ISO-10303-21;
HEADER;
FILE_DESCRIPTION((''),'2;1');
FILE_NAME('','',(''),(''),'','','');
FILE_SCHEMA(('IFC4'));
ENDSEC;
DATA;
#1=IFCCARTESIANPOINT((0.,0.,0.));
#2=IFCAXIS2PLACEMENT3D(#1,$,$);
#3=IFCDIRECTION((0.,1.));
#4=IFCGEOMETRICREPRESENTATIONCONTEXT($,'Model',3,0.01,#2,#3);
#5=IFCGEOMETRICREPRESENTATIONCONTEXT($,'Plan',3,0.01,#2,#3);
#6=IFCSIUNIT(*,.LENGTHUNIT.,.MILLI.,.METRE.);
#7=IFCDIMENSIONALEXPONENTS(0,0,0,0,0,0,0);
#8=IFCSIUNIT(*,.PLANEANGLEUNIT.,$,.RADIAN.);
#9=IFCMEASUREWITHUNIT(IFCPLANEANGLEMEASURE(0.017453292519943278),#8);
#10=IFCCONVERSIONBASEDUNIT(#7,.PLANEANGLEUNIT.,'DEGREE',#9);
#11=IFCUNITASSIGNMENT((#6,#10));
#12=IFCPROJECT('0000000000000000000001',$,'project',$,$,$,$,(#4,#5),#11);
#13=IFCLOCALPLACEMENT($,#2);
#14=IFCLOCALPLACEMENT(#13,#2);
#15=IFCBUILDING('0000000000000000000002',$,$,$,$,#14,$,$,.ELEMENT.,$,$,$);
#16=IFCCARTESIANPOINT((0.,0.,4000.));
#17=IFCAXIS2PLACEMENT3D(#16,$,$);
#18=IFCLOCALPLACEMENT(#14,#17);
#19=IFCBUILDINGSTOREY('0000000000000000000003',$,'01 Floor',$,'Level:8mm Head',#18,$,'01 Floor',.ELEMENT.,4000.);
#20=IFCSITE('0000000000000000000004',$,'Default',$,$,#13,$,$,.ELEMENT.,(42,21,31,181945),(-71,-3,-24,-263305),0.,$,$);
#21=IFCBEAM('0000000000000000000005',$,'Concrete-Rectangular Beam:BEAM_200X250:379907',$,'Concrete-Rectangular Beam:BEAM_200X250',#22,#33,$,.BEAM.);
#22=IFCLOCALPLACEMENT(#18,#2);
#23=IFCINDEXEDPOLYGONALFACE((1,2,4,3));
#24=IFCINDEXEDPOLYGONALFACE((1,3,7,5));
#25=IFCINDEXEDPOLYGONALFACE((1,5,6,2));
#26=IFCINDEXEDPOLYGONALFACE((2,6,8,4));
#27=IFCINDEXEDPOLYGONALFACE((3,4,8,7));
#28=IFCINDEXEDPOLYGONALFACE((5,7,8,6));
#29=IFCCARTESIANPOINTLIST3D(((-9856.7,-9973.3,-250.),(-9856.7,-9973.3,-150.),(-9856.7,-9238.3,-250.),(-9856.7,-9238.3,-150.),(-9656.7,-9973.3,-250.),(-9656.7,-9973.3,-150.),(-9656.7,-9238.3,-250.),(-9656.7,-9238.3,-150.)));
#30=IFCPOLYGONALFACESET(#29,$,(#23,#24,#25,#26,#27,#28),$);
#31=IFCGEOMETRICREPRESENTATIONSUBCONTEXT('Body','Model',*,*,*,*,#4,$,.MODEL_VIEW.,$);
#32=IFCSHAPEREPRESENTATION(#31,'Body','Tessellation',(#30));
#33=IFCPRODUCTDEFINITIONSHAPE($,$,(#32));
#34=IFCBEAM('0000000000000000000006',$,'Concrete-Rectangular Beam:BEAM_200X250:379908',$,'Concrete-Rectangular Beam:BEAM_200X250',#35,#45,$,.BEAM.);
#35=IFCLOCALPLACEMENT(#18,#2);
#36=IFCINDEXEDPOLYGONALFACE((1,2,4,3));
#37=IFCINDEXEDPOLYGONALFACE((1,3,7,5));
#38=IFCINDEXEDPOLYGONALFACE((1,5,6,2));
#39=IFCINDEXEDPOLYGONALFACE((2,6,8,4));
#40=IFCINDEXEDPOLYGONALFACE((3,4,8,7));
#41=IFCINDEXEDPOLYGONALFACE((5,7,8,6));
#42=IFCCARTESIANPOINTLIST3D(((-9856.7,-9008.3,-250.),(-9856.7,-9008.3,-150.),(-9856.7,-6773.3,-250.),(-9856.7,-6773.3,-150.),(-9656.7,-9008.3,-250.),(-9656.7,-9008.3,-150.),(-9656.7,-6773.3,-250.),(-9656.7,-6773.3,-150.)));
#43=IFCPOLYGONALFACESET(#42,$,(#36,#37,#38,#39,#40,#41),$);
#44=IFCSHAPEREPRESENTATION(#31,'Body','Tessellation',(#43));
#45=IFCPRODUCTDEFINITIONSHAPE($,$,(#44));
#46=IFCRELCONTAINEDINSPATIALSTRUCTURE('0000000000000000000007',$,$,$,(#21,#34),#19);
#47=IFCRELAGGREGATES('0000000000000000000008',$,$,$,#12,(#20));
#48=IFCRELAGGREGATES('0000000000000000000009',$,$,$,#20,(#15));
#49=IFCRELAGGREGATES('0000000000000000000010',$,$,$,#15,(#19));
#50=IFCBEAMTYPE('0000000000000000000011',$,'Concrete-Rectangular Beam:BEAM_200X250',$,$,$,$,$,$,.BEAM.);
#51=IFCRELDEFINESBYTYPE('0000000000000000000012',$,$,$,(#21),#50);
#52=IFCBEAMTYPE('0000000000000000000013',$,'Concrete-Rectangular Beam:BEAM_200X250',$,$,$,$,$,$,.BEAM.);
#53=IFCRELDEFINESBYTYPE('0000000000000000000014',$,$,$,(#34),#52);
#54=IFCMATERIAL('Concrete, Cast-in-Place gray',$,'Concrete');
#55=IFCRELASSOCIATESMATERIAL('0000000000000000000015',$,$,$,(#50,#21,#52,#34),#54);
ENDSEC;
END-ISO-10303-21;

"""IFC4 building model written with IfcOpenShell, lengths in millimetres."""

from ifc_helpers import new_model, entity, si_unit, converted_unit, direction, frame, origin, place, context, subcontext, project, spatial, indexed_curve, outline, extrude, source, transform, mapped, material, type_object, type_shapes, element, save


model = new_model("IFC4")

# Units and contexts
model_context = context("Model", 3, precision=0.01, world=origin(), true_north=direction((0.0, 1.0)))
plan_context = context("Plan", 3, precision=0.01, world=origin(), true_north=direction((0.0, 1.0)))
body_context = subcontext(model_context, "Body", "Model", "MODEL_VIEW")
ifc_project = project(units=[si_unit("LENGTHUNIT", "METRE", prefix="MILLI"), converted_unit("PLANEANGLEUNIT", "DEGREE", entity("IfcPlaneAngleMeasure", 0.017453292519943278), si_unit("PLANEANGLEUNIT", "RADIAN"), dimensions=[0, 0, 0, 0, 0, 0, 0])], contexts=[model_context, plan_context])

# Site, building, storey
site_placement = place(None, origin())
site = spatial("IfcSite", under=ifc_project, at=site_placement, Name="Default", CompositionType="ELEMENT", RefLatitude=(42, 21, 31, 181945), RefLongitude=(-71, -3, -24, -263305), RefElevation=0.0)
building_placement = place(site_placement, origin())
building = spatial("IfcBuilding", under=site, at=building_placement, CompositionType="ELEMENT")
storey_placement = place(building_placement, frame((0.0, 0.0, 4000.0)))
storey = spatial("IfcBuildingStorey", under=building, at=storey_placement, Name="01 Floor", ObjectType="Level:8mm Head", LongName="01 Floor", CompositionType="ELEMENT", Elevation=4000.0)

# Beams
ifc_material = material(Name="Concrete, Cast-in-Place gray", Category="Concrete")
beam_type_1 = type_object("IfcBeamType", Name="Concrete-Rectangular Beam:BEAM_200X250", PredefinedType="BEAM", material=ifc_material)
shared_shape_1 = source(origin(), body_context, "Body", "SweptSolid", [
    extrude(outline(indexed_curve([(-100.0, -50.0), (100.0, -50.0), (100.0, 50.0), (-100.0, 50.0), (-100.0, -50.0)], self_intersect=False)), frame((-9756.7, -9973.3, 3800.0), z_axis=(0.0, 1.0, 0.0), x_axis=(-1.0, 0.0, 0.0)), (0.0, 0.0, 1.0), 735.0),
])
type_shapes(beam_type_1, [shared_shape_1])
beam_1_placement = place(storey_placement, frame((0.0, 0.0, -4000.0)))
element("IfcBeam", 1, at=beam_1_placement, inside=storey, type_object=beam_type_1, material=ifc_material, Name="Concrete-Rectangular Beam:BEAM_200X250:379907", ObjectType="Concrete-Rectangular Beam:BEAM_200X250", PredefinedType="BEAM", context=body_context, shape_type="MappedRepresentation", body=[
    mapped(shared_shape_1, transform((0.0, 0.0, 0.0), scale=1.0)),
])
beam_type_2 = type_object("IfcBeamType", Name="Concrete-Rectangular Beam:BEAM_200X250", PredefinedType="BEAM", material=ifc_material)
shared_shape_2 = source(origin(), body_context, "Body", "SweptSolid", [
    extrude(outline(indexed_curve([(-100.0, -50.0), (100.0, -50.0), (100.0, 50.0), (-100.0, 50.0), (-100.0, -50.0)], self_intersect=False)), frame((-9756.7, -9008.3, 3800.0), z_axis=(0.0, 1.0, 0.0), x_axis=(-1.0, 0.0, 0.0)), (0.0, 0.0, 1.0), 2235.0),
])
type_shapes(beam_type_2, [shared_shape_2])
beam_2_placement = place(storey_placement, frame((0.0, 0.0, -4000.0)))
element("IfcBeam", 2, at=beam_2_placement, inside=storey, type_object=beam_type_2, material=ifc_material, Name="Concrete-Rectangular Beam:BEAM_200X250:379908", ObjectType="Concrete-Rectangular Beam:BEAM_200X250", PredefinedType="BEAM", context=body_context, shape_type="MappedRepresentation", body=[
    mapped(shared_shape_2, transform((0.0, 0.0, 0.0), scale=1.0)),
])

save(model, "model.ifc")
